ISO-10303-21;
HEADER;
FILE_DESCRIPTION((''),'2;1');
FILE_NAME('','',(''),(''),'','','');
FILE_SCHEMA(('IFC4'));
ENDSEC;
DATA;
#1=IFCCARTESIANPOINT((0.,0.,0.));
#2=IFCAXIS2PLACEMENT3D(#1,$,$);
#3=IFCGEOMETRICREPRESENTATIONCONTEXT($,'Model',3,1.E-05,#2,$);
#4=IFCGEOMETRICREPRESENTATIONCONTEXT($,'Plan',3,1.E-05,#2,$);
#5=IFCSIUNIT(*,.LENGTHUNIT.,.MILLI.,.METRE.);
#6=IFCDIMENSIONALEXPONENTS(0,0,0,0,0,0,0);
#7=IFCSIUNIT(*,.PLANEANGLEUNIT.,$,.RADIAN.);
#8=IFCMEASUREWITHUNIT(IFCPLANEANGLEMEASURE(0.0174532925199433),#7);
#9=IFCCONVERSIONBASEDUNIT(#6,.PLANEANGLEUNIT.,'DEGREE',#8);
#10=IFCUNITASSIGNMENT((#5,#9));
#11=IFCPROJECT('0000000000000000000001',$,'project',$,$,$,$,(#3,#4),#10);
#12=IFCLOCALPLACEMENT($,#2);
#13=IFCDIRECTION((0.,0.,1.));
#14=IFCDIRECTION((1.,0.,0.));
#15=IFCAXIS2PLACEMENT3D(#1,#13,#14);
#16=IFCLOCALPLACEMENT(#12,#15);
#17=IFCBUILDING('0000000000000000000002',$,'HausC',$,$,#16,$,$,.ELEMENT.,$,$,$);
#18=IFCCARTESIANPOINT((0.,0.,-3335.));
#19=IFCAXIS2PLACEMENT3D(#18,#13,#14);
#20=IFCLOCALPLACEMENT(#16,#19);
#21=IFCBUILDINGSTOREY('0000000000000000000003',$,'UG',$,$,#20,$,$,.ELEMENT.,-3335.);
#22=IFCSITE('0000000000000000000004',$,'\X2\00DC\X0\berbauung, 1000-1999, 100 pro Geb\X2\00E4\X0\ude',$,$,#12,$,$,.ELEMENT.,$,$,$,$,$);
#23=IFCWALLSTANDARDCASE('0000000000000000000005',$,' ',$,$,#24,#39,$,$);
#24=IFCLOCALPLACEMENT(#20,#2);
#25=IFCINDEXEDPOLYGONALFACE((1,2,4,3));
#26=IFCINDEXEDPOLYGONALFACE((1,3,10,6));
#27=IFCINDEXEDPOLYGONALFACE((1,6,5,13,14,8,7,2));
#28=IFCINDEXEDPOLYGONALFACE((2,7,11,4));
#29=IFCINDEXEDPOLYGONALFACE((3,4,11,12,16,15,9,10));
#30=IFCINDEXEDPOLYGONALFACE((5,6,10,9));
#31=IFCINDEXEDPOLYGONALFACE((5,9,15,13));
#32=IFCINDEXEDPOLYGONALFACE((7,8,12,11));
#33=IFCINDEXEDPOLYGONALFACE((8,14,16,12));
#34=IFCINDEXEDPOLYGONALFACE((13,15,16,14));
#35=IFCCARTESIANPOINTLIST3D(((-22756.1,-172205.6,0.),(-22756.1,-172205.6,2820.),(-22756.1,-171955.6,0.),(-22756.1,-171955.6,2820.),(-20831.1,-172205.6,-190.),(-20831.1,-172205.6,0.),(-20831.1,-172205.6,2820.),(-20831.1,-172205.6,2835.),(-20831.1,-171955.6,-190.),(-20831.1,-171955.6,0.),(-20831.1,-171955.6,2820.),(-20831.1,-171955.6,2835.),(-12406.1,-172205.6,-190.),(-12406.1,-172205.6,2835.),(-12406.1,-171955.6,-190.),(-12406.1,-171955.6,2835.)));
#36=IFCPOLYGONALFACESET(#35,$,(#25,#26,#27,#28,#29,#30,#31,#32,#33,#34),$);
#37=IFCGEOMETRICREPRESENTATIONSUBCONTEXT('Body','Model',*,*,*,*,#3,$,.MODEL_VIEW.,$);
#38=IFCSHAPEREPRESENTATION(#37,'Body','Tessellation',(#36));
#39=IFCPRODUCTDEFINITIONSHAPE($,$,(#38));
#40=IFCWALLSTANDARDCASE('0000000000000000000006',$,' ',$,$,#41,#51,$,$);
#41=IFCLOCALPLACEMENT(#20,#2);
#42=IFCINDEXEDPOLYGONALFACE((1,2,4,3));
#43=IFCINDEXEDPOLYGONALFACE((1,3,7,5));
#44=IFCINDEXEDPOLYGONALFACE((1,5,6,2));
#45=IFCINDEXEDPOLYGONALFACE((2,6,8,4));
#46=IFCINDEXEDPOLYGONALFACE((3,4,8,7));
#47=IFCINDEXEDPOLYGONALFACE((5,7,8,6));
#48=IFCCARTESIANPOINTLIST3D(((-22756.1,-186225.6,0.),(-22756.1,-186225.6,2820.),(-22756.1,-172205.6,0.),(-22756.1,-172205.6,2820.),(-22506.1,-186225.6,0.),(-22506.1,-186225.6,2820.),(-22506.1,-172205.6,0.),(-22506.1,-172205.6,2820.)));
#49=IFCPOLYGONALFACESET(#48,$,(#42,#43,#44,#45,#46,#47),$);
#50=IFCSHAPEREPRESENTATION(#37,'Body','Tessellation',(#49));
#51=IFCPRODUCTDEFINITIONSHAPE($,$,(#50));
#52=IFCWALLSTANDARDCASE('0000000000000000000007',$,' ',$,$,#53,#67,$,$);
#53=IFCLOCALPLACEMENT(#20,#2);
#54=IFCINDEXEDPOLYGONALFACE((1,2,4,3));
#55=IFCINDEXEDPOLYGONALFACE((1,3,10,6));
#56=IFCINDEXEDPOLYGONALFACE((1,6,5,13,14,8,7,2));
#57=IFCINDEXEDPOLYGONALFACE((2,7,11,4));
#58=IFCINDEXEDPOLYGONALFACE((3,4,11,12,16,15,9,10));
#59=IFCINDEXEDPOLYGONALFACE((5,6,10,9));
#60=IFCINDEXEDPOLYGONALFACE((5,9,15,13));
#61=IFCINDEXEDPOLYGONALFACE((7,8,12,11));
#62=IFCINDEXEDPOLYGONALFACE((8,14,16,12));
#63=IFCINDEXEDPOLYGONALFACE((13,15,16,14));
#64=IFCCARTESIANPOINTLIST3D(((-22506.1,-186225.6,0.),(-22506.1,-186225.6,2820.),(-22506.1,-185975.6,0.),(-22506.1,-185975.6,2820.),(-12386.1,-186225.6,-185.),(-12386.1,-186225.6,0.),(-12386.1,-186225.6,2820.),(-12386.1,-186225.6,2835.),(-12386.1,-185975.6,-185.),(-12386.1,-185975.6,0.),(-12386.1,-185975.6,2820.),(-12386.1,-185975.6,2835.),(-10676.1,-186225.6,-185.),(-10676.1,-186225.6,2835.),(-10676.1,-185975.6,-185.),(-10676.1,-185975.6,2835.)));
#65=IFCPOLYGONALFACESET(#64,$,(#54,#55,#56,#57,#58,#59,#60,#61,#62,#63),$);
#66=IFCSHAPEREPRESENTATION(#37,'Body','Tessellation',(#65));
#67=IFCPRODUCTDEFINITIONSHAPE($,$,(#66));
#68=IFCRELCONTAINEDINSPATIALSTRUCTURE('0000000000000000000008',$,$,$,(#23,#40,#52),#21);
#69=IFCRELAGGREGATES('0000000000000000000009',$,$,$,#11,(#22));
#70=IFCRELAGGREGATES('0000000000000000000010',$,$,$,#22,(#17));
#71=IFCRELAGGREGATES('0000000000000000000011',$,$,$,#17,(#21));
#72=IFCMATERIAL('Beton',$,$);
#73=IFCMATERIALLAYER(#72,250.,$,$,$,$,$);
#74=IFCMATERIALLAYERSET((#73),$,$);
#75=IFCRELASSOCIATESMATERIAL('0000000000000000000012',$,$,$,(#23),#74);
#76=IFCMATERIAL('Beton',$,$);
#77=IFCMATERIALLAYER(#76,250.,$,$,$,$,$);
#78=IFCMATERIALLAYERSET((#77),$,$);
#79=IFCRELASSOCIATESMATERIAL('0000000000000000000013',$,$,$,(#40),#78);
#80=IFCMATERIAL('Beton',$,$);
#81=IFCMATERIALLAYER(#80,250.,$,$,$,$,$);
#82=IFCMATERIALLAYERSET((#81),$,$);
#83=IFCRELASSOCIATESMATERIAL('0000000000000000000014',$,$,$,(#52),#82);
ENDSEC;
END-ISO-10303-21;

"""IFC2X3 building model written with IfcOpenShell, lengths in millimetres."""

from ifc_helpers import new_model, entity, si_unit, converted_unit, frame, frame_2d, origin, origin_with_axes, place, context, subcontext, project, spatial, polyline, rectangle, extrude, clip, bounded_halfspace, material, layer, layer_set, layer_usage, element, save


model = new_model("IFC2X3")

# Units and contexts
model_context = context("Model", 3, precision=1e-05, world=origin())
plan_context = context("Plan", 3, precision=1e-05, world=origin())
body_context = subcontext(model_context, "Body", "Model", "MODEL_VIEW")
ifc_project = project(units=[si_unit("LENGTHUNIT", "METRE", prefix="MILLI"), converted_unit("PLANEANGLEUNIT", "DEGREE", entity("IfcPlaneAngleMeasure", 0.0174532925199433), si_unit("PLANEANGLEUNIT", "RADIAN"), dimensions=[0, 0, 0, 0, 0, 0, 0])], contexts=[model_context, plan_context])

# Site, building, storey
site_placement = place(None, origin())
site = spatial("IfcSite", under=ifc_project, at=site_placement, Name="Überbauung, 1000-1999, 100 pro Gebäude", CompositionType="ELEMENT")
building_placement = place(site_placement, origin_with_axes())
building = spatial("IfcBuilding", under=site, at=building_placement, Name="HausC", CompositionType="ELEMENT")
storey_placement = place(building_placement, frame((0.0, 0.0, -3335.0), z_axis=(0.0, 0.0, 1.0), x_axis=(1.0, 0.0, 0.0)))
storey = spatial("IfcBuildingStorey", under=building, at=storey_placement, Name="UG", CompositionType="ELEMENT", Elevation=-3335.0)

# Walls
ifc_material_1 = material(Name="Beton")
ifc_layer_1 = layer(ifc_material_1, 250.0)
ifc_layer_set_1 = layer_set([ifc_layer_1])
ifc_layer_usage_1 = layer_usage(ifc_layer_set_1, "AXIS2", "POSITIVE", 0.0)
wall_1_placement = place(storey_placement, frame((-12406.1, -171955.6, -190.0), z_axis=(0.0, 0.0, 1.0), x_axis=(-1.0, 0.0, 0.0)))
element("IfcWallStandardCase", 1, at=wall_1_placement, inside=storey, material=ifc_layer_usage_1, Name=" ", context=body_context, shape_type="Clipping", body=[
    clip(clip(clip(clip(extrude(rectangle(XDim=10350.0, YDim=250.0, at=frame_2d((5175.0, 125.0), x_axis=(1.0, 0.0))), origin_with_axes(), (0.0, 0.0, 1.0), 3025.0), bounded_halfspace(frame((8425.0, 0.0, 0.0), z_axis=(0.0, 0.0, 1.0), x_axis=(0.0, 1.0, 0.0)), True, origin(), polyline([(8425.0, 0.0), (8425.0, 250.0), (0.0, 250.0), (0.0, 0.0), (8425.0, 0.0)]))), bounded_halfspace(frame((8425.0, 250.0, 3025.0), z_axis=(0.0, 0.0, -1.0), x_axis=(-1.0, 0.0, 0.0)), True, origin(), polyline([(8425.0, 250.0), (0.0, 250.0), (0.0, 0.0), (8425.0, 0.0), (8425.0, 250.0)]))), bounded_halfspace(frame((10350.0, 250.0, 190.0), z_axis=(0.0, 0.0, 1.0), x_axis=(-1.0, 0.0, 0.0)), True, origin(), polyline([(10350.0, 250.0), (8425.0, 250.0), (8425.0, 0.0), (10350.0, 0.0), (10350.0, 250.0)]))), bounded_halfspace(frame((8425.0, 250.0, 3010.0), z_axis=(0.0, 0.0, -1.0), x_axis=(0.0, -1.0, 0.0)), True, origin(), polyline([(8425.0, 250.0), (8425.0, 0.0), (10350.0, 0.0), (10350.0, 250.0), (8425.0, 250.0)]))),
])
ifc_material_2 = material(Name="Beton")
ifc_layer_2 = layer(ifc_material_2, 250.0)
ifc_layer_set_2 = layer_set([ifc_layer_2])
ifc_layer_usage_2 = layer_usage(ifc_layer_set_2, "AXIS2", "POSITIVE", 0.0)
wall_2_placement = place(storey_placement, frame((-22756.1, -172205.6, 0.0), z_axis=(0.0, 0.0, 1.0), x_axis=(0.0, -1.0, 0.0)))
element("IfcWallStandardCase", 2, at=wall_2_placement, inside=storey, material=ifc_layer_usage_2, Name=" ", context=body_context, shape_type="SweptSolid", body=[
    extrude(rectangle(XDim=14020.0, YDim=250.0, at=frame_2d((7010.0, 125.0), x_axis=(1.0, 0.0))), origin_with_axes(), (0.0, 0.0, 1.0), 2820.0),
])
ifc_material_3 = material(Name="Beton")
ifc_layer_3 = layer(ifc_material_3, 250.0)
ifc_layer_set_3 = layer_set([ifc_layer_3])
ifc_layer_usage_3 = layer_usage(ifc_layer_set_3, "AXIS2", "POSITIVE", 0.0)
wall_3_placement = place(storey_placement, frame((-22506.1, -186225.6, -185.0), z_axis=(0.0, 0.0, 1.0), x_axis=(1.0, 0.0, 0.0)))
element("IfcWallStandardCase", 3, at=wall_3_placement, inside=storey, material=ifc_layer_usage_3, Name=" ", context=body_context, shape_type="Clipping", body=[
    clip(clip(clip(clip(extrude(rectangle(XDim=11830.0, YDim=250.0, at=frame_2d((5915.0, 125.0), x_axis=(1.0, 0.0))), origin_with_axes(), (0.0, 0.0, 1.0), 3020.0), bounded_halfspace(frame((10120.0, 250.0, 0.0), z_axis=(0.0, 0.0, 1.0), x_axis=(0.0, -1.0, 0.0)), True, origin(), polyline([(10120.0, 250.0), (10120.0, 0.0), (11830.0, 0.0), (11830.0, 250.0), (10120.0, 250.0)]))), bounded_halfspace(frame((10120.0, 0.0, 3020.0), z_axis=(0.0, 0.0, -1.0), x_axis=(1.0, 0.0, 0.0)), True, origin(), polyline([(10120.0, 0.0), (11830.0, 0.0), (11830.0, 250.0), (10120.0, 250.0), (10120.0, 0.0)]))), bounded_halfspace(frame((0.0, 0.0, 185.0), z_axis=(0.0, 0.0, 1.0), x_axis=(1.0, 0.0, 0.0)), True, origin(), polyline([(0.0, 0.0), (10120.0, 0.0), (10120.0, 250.0), (0.0, 250.0), (0.0, 0.0)]))), bounded_halfspace(frame((10120.0, 0.0, 3005.0), z_axis=(0.0, 0.0, -1.0), x_axis=(0.0, 1.0, 0.0)), True, origin(), polyline([(10120.0, 0.0), (10120.0, 250.0), (0.0, 250.0), (0.0, 0.0), (10120.0, 0.0)]))),
])

save(model, "model.ifc")
